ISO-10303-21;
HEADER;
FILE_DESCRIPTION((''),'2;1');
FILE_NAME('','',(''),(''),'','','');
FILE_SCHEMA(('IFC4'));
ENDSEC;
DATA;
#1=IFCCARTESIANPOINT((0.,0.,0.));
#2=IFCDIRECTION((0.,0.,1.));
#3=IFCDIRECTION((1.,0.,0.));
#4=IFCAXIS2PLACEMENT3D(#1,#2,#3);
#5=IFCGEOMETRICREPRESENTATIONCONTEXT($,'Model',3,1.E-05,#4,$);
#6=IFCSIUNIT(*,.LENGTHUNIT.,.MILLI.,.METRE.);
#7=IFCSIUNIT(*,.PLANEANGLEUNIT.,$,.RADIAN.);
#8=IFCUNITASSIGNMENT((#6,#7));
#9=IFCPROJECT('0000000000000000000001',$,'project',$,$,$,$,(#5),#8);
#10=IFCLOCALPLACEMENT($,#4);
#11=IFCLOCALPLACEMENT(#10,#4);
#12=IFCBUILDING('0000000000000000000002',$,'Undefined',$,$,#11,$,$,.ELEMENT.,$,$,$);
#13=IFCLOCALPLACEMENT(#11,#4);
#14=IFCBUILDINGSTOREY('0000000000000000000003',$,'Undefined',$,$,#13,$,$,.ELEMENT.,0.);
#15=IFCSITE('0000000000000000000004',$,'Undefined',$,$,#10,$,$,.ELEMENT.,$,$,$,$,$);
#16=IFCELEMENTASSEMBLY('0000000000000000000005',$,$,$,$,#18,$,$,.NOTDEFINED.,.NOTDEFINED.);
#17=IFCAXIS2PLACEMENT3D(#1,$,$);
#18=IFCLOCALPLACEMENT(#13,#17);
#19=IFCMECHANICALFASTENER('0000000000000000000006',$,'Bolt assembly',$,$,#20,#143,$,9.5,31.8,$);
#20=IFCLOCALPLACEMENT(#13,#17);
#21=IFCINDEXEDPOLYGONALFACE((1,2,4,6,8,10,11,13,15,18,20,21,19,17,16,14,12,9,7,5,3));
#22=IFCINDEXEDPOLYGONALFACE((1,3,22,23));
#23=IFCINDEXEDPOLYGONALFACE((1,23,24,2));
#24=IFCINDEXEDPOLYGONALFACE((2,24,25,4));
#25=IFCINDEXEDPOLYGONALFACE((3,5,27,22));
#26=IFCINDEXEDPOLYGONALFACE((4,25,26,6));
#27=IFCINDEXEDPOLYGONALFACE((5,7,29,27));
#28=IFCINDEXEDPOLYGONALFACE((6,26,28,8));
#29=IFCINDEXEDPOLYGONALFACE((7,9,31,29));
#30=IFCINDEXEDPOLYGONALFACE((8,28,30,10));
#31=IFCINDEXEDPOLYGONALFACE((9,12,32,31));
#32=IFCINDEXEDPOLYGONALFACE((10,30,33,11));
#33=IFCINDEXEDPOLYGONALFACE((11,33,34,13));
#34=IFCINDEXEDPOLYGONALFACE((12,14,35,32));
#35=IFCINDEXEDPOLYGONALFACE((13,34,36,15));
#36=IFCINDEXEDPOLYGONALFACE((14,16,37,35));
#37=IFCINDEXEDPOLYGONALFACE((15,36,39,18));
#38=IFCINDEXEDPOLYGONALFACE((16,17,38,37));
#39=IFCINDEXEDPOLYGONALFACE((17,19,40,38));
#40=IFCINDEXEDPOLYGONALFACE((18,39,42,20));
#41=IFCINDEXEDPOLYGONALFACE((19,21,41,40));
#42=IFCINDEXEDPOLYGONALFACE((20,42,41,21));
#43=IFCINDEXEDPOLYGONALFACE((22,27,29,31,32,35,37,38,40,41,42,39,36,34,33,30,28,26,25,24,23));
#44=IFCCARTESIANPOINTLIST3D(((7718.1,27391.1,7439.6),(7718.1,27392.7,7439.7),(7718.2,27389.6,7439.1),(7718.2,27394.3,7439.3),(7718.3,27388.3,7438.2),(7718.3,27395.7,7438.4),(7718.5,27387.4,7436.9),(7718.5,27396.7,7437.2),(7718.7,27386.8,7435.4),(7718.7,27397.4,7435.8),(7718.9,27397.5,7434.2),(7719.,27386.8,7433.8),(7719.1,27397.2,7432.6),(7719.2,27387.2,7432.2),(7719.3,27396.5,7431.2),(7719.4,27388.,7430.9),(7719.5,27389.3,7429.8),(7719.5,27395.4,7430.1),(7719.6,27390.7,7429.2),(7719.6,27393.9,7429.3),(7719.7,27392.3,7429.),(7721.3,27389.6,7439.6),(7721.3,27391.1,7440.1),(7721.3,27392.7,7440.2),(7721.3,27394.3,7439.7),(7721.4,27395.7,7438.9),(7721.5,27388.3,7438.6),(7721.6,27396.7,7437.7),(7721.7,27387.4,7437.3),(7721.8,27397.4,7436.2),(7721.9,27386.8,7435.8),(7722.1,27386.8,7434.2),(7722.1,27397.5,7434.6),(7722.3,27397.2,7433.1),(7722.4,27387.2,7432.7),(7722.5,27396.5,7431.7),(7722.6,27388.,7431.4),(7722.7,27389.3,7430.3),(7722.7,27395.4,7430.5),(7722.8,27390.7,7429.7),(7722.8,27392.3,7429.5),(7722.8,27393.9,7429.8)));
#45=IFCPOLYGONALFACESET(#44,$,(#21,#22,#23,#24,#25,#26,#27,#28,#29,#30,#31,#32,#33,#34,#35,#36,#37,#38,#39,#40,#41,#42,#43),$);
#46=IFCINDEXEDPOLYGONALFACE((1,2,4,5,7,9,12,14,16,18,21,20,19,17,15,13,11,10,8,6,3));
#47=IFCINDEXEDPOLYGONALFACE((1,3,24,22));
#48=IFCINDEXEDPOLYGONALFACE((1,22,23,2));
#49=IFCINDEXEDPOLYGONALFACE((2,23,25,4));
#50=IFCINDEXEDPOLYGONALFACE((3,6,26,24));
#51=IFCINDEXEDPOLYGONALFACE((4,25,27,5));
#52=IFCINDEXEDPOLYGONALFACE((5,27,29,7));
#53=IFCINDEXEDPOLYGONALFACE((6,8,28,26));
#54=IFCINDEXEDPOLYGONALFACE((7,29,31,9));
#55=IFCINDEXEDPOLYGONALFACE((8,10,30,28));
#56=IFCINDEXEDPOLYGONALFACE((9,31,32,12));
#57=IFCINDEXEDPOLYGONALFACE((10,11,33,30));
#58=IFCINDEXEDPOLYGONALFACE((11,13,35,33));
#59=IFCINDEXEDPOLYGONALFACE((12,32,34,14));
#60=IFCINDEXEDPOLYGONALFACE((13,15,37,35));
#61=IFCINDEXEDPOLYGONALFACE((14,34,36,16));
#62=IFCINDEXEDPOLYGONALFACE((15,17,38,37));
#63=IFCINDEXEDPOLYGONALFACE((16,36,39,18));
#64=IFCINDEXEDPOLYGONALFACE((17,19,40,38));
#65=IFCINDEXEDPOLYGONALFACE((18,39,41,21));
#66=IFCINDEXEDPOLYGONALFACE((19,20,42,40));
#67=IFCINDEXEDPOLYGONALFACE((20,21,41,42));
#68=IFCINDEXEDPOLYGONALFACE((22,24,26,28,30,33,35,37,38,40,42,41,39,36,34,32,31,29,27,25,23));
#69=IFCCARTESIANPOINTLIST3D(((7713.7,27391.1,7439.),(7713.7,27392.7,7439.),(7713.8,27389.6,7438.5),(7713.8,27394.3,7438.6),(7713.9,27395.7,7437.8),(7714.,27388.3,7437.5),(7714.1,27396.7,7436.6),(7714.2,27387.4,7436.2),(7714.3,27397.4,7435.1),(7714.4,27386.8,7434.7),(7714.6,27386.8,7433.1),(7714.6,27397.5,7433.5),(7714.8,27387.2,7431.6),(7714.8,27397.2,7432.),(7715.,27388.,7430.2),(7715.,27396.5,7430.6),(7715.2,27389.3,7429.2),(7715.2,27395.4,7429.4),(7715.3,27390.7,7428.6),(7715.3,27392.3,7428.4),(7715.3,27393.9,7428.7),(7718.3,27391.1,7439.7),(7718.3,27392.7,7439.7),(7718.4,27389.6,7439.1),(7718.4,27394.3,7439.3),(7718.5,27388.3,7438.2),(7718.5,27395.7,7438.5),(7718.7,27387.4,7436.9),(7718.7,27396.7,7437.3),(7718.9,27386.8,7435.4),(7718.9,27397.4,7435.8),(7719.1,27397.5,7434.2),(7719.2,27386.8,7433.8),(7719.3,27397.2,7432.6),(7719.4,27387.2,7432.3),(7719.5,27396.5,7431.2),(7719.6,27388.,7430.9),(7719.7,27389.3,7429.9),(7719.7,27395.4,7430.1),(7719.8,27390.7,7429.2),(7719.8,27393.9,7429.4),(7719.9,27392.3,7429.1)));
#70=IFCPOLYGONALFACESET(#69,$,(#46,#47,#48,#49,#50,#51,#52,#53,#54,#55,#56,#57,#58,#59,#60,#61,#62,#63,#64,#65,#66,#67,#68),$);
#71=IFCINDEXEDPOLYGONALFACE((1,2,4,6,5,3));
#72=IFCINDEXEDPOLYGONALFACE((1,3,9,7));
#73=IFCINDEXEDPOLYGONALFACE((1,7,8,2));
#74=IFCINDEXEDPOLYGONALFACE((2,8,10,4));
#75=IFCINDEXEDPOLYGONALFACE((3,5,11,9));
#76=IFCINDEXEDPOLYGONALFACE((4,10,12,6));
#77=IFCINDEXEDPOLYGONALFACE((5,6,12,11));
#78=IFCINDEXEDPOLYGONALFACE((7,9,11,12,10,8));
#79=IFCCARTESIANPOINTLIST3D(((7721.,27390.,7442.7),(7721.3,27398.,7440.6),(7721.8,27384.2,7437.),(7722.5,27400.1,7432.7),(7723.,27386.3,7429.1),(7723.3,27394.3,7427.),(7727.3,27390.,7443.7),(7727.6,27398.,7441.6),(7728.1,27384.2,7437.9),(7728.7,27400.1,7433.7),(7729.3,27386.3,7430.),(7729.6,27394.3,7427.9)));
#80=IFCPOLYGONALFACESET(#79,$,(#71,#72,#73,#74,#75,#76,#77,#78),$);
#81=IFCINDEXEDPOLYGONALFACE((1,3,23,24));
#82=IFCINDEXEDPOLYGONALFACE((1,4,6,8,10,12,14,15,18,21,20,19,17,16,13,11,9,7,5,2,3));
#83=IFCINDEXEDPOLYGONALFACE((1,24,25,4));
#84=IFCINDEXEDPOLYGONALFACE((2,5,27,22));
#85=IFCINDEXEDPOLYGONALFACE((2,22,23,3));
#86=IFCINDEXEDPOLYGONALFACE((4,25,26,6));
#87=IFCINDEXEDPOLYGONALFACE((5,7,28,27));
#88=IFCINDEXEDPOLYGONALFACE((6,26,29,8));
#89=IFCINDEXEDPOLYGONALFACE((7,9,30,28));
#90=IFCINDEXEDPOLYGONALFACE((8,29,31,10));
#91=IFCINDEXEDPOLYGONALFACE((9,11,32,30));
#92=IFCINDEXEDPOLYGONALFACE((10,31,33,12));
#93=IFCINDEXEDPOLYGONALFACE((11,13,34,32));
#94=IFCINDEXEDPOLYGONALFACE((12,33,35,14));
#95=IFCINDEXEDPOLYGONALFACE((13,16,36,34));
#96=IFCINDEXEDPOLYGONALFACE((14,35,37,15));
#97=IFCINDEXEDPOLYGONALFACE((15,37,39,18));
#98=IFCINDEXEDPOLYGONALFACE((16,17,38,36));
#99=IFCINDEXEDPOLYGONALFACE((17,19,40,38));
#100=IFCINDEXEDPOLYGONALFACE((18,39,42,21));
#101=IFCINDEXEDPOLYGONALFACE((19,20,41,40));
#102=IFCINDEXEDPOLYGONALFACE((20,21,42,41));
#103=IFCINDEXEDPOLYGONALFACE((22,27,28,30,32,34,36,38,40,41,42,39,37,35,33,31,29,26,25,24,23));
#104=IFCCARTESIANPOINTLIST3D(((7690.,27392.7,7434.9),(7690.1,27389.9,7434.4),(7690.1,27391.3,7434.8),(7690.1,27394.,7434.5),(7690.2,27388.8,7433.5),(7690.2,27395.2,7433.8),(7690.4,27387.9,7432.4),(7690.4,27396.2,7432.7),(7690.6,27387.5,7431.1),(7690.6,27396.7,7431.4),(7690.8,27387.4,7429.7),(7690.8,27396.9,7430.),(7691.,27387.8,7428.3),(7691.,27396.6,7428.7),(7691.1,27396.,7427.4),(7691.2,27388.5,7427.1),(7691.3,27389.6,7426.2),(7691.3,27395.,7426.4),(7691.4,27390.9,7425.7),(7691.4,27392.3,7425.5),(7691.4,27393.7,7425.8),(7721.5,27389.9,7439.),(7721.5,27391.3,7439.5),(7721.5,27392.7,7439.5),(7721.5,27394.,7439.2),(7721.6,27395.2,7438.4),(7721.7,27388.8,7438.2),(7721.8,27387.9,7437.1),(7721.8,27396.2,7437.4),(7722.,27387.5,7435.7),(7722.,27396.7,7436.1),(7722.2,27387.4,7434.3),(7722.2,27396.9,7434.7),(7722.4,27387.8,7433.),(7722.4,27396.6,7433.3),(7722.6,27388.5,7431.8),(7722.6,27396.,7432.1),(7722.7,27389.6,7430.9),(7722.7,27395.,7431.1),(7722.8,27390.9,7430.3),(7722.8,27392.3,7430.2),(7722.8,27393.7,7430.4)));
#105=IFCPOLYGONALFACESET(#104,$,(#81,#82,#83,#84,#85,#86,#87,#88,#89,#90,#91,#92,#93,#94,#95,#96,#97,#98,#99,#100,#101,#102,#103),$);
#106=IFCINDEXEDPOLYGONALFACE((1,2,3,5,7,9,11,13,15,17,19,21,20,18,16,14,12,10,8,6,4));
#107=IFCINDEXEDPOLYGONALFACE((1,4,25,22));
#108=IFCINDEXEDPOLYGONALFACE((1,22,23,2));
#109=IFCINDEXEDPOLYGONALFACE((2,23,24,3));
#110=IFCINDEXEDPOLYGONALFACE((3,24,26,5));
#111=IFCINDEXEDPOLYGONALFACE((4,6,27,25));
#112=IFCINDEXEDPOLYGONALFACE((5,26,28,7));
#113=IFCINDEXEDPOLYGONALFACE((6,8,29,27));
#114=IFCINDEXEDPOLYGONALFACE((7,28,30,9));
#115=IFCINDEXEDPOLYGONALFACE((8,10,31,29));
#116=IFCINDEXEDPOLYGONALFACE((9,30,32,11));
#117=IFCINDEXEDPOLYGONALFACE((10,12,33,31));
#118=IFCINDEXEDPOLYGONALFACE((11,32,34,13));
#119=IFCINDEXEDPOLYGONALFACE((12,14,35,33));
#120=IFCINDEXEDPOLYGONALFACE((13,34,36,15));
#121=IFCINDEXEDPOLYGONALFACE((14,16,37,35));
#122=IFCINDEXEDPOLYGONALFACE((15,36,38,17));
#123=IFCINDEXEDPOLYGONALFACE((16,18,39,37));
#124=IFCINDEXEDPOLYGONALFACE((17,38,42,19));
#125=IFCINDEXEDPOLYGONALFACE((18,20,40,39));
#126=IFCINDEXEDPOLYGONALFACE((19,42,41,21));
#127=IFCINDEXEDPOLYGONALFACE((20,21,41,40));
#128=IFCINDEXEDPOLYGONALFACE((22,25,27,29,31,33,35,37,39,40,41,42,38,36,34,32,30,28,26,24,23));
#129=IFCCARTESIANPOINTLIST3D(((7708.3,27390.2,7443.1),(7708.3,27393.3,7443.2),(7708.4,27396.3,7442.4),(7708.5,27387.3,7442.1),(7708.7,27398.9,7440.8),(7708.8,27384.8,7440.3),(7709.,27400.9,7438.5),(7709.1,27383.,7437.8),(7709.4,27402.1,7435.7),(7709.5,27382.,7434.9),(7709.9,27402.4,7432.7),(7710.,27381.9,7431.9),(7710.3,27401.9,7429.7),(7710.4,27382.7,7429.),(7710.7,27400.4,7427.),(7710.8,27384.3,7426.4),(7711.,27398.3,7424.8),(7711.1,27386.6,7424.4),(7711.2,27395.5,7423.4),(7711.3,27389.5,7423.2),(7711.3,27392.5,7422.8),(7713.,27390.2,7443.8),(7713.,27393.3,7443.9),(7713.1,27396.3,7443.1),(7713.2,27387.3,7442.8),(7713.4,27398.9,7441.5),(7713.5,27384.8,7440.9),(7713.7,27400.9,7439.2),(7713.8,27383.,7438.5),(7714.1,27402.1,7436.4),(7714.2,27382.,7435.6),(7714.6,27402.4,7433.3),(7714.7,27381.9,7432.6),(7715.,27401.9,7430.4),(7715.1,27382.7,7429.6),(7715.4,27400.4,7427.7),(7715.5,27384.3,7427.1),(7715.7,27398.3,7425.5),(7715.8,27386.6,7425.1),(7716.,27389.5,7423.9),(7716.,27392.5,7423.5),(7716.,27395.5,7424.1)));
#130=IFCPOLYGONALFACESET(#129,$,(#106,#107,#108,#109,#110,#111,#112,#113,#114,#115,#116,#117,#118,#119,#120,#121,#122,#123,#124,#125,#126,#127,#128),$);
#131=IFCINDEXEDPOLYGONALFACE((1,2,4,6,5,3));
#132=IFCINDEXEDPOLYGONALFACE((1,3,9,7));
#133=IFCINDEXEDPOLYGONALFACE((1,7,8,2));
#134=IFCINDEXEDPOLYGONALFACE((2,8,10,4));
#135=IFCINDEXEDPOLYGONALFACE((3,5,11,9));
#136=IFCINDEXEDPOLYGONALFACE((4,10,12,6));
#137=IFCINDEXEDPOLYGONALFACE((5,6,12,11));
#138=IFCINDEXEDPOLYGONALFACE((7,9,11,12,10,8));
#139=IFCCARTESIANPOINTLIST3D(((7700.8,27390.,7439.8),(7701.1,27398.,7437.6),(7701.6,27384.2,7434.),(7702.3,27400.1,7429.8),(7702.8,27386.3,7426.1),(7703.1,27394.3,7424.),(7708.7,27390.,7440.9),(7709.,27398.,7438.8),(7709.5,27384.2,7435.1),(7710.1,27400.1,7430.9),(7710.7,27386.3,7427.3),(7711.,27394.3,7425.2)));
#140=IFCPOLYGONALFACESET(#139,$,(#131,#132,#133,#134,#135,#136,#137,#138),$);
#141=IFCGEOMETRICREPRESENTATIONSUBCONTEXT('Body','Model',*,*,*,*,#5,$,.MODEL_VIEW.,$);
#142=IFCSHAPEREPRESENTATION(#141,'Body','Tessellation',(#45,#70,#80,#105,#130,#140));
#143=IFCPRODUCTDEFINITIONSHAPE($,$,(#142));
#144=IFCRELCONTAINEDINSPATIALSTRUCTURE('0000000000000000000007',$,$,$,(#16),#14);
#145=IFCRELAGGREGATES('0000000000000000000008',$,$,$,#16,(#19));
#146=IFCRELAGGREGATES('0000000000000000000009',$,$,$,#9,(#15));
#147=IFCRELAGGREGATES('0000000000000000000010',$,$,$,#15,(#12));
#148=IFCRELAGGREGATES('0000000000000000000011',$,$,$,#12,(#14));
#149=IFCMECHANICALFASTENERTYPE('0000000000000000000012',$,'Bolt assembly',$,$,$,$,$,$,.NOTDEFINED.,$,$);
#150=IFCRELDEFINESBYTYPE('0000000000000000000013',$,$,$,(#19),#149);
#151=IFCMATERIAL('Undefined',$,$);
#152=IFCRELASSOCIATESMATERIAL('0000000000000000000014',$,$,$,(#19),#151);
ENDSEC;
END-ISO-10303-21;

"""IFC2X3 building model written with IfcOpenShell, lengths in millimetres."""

from ifc_helpers import new_model, si_unit, frame, origin_with_axes, origin_2d_with_axis, place, context, subcontext, project, spatial, polyline, circle, outline, extrude, source, transform, mapped, material, type_object, element, aggregate, save


model = new_model("IFC2X3")

# Units and contexts
model_context = context("Model", 3, precision=1e-05, world=origin_with_axes())
body_context = subcontext(model_context, "Body", "Model", "MODEL_VIEW")
ifc_project = project(units=[si_unit("LENGTHUNIT", "METRE", prefix="MILLI"), si_unit("PLANEANGLEUNIT", "RADIAN")], contexts=[model_context])

# Site, building, storey
site_placement = place(None, origin_with_axes())
site = spatial("IfcSite", under=ifc_project, at=site_placement, Name="Undefined", CompositionType="ELEMENT")
building_placement = place(site_placement, origin_with_axes())
building = spatial("IfcBuilding", under=site, at=building_placement, Name="Undefined", CompositionType="ELEMENT")
storey_placement = place(building_placement, origin_with_axes())
storey = spatial("IfcBuildingStorey", under=building, at=storey_placement, Name="Undefined", CompositionType="ELEMENT", Elevation=0.0)

# Element assembly
assembly_1_placement = place(storey_placement, origin_with_axes())
assembly_1 = element("IfcElementAssembly", 1, at=assembly_1_placement, inside=storey, AssemblyPlace="NOTDEFINED", PredefinedType="NOTDEFINED")

# Shared definitions
ifc_material_1 = material(Name="Undefined")
mechanical_fastener_type = type_object("IfcMechanicalFastenerType", Name="Bolt assembly")

# Mechanical fastener
shared_shape_1 = source(origin_with_axes(), body_context, "Body", "SweptSolid", [
    extrude(circle(Radius=5.4, at=origin_2d_with_axis()), frame((0.0, -3.1, 0.0), z_axis=(0.0, 1.0, 0.0), x_axis=(1.0, 0.0, 0.0)), (0.0, 0.0, 1.0), 3.2),
    extrude(circle(Radius=5.4, at=origin_2d_with_axis()), frame((0.0, -0.1, 0.0), z_axis=(0.0, 1.0, 0.0), x_axis=(1.0, 0.0, 0.0)), (0.0, 0.0, 1.0), 4.6),
    extrude(outline(polyline([(7.1, -4.1), (7.1, 4.1), (0.0, 8.2), (-7.1, 4.1), (-7.1, -4.1), (0.0, -8.2), (7.1, -4.1)])), frame((0.0, -9.6, 0.0), z_axis=(0.0, 1.0, 0.0), x_axis=(1.0, 0.0, 0.0)), (0.0, 0.0, 1.0), 6.3),
    extrude(circle(Radius=4.8, at=origin_2d_with_axis()), frame((0.0, -3.2, 0.0), z_axis=(0.0, 1.0, 0.0), x_axis=(1.0, 0.0, 0.0)), (0.0, 0.0, 1.0), 31.8),
    extrude(circle(Radius=10.3, at=origin_2d_with_axis()), frame((0.0, 4.5, 0.0), z_axis=(0.0, 1.0, 0.0), x_axis=(1.0, 0.0, 0.0)), (0.0, 0.0, 1.0), 4.8),
    extrude(outline(polyline([(7.1, -4.1), (7.1, 4.1), (0.0, 8.2), (-7.1, 4.1), (-7.1, -4.1), (0.0, -8.2), (7.1, -4.1)])), frame((0.0, 9.3, 0.0), z_axis=(0.0, 1.0, 0.0), x_axis=(1.0, 0.0, 0.0)), (0.0, 0.0, 1.0), 7.9),
])
mechanical_fastener_1_placement = place(assembly_1_placement, frame((7719.0, 27392.1, 7434.4), z_axis=(0.103381, -0.707107, -0.699509), x_axis=(-0.103381, -0.707107, 0.699509)))
mechanical_fastener_1 = element("IfcMechanicalFastener", 2, at=mechanical_fastener_1_placement, type_object=mechanical_fastener_type, material=ifc_material_1, Name="Bolt assembly", NominalDiameter=9.5, NominalLength=31.8, context=body_context, shape_type="MappedRepresentation", body=[
    mapped(shared_shape_1, transform((0.0, 0.0, 0.0))),
])
aggregate(assembly_1, [mechanical_fastener_1])

save(model, "model.ifc")
